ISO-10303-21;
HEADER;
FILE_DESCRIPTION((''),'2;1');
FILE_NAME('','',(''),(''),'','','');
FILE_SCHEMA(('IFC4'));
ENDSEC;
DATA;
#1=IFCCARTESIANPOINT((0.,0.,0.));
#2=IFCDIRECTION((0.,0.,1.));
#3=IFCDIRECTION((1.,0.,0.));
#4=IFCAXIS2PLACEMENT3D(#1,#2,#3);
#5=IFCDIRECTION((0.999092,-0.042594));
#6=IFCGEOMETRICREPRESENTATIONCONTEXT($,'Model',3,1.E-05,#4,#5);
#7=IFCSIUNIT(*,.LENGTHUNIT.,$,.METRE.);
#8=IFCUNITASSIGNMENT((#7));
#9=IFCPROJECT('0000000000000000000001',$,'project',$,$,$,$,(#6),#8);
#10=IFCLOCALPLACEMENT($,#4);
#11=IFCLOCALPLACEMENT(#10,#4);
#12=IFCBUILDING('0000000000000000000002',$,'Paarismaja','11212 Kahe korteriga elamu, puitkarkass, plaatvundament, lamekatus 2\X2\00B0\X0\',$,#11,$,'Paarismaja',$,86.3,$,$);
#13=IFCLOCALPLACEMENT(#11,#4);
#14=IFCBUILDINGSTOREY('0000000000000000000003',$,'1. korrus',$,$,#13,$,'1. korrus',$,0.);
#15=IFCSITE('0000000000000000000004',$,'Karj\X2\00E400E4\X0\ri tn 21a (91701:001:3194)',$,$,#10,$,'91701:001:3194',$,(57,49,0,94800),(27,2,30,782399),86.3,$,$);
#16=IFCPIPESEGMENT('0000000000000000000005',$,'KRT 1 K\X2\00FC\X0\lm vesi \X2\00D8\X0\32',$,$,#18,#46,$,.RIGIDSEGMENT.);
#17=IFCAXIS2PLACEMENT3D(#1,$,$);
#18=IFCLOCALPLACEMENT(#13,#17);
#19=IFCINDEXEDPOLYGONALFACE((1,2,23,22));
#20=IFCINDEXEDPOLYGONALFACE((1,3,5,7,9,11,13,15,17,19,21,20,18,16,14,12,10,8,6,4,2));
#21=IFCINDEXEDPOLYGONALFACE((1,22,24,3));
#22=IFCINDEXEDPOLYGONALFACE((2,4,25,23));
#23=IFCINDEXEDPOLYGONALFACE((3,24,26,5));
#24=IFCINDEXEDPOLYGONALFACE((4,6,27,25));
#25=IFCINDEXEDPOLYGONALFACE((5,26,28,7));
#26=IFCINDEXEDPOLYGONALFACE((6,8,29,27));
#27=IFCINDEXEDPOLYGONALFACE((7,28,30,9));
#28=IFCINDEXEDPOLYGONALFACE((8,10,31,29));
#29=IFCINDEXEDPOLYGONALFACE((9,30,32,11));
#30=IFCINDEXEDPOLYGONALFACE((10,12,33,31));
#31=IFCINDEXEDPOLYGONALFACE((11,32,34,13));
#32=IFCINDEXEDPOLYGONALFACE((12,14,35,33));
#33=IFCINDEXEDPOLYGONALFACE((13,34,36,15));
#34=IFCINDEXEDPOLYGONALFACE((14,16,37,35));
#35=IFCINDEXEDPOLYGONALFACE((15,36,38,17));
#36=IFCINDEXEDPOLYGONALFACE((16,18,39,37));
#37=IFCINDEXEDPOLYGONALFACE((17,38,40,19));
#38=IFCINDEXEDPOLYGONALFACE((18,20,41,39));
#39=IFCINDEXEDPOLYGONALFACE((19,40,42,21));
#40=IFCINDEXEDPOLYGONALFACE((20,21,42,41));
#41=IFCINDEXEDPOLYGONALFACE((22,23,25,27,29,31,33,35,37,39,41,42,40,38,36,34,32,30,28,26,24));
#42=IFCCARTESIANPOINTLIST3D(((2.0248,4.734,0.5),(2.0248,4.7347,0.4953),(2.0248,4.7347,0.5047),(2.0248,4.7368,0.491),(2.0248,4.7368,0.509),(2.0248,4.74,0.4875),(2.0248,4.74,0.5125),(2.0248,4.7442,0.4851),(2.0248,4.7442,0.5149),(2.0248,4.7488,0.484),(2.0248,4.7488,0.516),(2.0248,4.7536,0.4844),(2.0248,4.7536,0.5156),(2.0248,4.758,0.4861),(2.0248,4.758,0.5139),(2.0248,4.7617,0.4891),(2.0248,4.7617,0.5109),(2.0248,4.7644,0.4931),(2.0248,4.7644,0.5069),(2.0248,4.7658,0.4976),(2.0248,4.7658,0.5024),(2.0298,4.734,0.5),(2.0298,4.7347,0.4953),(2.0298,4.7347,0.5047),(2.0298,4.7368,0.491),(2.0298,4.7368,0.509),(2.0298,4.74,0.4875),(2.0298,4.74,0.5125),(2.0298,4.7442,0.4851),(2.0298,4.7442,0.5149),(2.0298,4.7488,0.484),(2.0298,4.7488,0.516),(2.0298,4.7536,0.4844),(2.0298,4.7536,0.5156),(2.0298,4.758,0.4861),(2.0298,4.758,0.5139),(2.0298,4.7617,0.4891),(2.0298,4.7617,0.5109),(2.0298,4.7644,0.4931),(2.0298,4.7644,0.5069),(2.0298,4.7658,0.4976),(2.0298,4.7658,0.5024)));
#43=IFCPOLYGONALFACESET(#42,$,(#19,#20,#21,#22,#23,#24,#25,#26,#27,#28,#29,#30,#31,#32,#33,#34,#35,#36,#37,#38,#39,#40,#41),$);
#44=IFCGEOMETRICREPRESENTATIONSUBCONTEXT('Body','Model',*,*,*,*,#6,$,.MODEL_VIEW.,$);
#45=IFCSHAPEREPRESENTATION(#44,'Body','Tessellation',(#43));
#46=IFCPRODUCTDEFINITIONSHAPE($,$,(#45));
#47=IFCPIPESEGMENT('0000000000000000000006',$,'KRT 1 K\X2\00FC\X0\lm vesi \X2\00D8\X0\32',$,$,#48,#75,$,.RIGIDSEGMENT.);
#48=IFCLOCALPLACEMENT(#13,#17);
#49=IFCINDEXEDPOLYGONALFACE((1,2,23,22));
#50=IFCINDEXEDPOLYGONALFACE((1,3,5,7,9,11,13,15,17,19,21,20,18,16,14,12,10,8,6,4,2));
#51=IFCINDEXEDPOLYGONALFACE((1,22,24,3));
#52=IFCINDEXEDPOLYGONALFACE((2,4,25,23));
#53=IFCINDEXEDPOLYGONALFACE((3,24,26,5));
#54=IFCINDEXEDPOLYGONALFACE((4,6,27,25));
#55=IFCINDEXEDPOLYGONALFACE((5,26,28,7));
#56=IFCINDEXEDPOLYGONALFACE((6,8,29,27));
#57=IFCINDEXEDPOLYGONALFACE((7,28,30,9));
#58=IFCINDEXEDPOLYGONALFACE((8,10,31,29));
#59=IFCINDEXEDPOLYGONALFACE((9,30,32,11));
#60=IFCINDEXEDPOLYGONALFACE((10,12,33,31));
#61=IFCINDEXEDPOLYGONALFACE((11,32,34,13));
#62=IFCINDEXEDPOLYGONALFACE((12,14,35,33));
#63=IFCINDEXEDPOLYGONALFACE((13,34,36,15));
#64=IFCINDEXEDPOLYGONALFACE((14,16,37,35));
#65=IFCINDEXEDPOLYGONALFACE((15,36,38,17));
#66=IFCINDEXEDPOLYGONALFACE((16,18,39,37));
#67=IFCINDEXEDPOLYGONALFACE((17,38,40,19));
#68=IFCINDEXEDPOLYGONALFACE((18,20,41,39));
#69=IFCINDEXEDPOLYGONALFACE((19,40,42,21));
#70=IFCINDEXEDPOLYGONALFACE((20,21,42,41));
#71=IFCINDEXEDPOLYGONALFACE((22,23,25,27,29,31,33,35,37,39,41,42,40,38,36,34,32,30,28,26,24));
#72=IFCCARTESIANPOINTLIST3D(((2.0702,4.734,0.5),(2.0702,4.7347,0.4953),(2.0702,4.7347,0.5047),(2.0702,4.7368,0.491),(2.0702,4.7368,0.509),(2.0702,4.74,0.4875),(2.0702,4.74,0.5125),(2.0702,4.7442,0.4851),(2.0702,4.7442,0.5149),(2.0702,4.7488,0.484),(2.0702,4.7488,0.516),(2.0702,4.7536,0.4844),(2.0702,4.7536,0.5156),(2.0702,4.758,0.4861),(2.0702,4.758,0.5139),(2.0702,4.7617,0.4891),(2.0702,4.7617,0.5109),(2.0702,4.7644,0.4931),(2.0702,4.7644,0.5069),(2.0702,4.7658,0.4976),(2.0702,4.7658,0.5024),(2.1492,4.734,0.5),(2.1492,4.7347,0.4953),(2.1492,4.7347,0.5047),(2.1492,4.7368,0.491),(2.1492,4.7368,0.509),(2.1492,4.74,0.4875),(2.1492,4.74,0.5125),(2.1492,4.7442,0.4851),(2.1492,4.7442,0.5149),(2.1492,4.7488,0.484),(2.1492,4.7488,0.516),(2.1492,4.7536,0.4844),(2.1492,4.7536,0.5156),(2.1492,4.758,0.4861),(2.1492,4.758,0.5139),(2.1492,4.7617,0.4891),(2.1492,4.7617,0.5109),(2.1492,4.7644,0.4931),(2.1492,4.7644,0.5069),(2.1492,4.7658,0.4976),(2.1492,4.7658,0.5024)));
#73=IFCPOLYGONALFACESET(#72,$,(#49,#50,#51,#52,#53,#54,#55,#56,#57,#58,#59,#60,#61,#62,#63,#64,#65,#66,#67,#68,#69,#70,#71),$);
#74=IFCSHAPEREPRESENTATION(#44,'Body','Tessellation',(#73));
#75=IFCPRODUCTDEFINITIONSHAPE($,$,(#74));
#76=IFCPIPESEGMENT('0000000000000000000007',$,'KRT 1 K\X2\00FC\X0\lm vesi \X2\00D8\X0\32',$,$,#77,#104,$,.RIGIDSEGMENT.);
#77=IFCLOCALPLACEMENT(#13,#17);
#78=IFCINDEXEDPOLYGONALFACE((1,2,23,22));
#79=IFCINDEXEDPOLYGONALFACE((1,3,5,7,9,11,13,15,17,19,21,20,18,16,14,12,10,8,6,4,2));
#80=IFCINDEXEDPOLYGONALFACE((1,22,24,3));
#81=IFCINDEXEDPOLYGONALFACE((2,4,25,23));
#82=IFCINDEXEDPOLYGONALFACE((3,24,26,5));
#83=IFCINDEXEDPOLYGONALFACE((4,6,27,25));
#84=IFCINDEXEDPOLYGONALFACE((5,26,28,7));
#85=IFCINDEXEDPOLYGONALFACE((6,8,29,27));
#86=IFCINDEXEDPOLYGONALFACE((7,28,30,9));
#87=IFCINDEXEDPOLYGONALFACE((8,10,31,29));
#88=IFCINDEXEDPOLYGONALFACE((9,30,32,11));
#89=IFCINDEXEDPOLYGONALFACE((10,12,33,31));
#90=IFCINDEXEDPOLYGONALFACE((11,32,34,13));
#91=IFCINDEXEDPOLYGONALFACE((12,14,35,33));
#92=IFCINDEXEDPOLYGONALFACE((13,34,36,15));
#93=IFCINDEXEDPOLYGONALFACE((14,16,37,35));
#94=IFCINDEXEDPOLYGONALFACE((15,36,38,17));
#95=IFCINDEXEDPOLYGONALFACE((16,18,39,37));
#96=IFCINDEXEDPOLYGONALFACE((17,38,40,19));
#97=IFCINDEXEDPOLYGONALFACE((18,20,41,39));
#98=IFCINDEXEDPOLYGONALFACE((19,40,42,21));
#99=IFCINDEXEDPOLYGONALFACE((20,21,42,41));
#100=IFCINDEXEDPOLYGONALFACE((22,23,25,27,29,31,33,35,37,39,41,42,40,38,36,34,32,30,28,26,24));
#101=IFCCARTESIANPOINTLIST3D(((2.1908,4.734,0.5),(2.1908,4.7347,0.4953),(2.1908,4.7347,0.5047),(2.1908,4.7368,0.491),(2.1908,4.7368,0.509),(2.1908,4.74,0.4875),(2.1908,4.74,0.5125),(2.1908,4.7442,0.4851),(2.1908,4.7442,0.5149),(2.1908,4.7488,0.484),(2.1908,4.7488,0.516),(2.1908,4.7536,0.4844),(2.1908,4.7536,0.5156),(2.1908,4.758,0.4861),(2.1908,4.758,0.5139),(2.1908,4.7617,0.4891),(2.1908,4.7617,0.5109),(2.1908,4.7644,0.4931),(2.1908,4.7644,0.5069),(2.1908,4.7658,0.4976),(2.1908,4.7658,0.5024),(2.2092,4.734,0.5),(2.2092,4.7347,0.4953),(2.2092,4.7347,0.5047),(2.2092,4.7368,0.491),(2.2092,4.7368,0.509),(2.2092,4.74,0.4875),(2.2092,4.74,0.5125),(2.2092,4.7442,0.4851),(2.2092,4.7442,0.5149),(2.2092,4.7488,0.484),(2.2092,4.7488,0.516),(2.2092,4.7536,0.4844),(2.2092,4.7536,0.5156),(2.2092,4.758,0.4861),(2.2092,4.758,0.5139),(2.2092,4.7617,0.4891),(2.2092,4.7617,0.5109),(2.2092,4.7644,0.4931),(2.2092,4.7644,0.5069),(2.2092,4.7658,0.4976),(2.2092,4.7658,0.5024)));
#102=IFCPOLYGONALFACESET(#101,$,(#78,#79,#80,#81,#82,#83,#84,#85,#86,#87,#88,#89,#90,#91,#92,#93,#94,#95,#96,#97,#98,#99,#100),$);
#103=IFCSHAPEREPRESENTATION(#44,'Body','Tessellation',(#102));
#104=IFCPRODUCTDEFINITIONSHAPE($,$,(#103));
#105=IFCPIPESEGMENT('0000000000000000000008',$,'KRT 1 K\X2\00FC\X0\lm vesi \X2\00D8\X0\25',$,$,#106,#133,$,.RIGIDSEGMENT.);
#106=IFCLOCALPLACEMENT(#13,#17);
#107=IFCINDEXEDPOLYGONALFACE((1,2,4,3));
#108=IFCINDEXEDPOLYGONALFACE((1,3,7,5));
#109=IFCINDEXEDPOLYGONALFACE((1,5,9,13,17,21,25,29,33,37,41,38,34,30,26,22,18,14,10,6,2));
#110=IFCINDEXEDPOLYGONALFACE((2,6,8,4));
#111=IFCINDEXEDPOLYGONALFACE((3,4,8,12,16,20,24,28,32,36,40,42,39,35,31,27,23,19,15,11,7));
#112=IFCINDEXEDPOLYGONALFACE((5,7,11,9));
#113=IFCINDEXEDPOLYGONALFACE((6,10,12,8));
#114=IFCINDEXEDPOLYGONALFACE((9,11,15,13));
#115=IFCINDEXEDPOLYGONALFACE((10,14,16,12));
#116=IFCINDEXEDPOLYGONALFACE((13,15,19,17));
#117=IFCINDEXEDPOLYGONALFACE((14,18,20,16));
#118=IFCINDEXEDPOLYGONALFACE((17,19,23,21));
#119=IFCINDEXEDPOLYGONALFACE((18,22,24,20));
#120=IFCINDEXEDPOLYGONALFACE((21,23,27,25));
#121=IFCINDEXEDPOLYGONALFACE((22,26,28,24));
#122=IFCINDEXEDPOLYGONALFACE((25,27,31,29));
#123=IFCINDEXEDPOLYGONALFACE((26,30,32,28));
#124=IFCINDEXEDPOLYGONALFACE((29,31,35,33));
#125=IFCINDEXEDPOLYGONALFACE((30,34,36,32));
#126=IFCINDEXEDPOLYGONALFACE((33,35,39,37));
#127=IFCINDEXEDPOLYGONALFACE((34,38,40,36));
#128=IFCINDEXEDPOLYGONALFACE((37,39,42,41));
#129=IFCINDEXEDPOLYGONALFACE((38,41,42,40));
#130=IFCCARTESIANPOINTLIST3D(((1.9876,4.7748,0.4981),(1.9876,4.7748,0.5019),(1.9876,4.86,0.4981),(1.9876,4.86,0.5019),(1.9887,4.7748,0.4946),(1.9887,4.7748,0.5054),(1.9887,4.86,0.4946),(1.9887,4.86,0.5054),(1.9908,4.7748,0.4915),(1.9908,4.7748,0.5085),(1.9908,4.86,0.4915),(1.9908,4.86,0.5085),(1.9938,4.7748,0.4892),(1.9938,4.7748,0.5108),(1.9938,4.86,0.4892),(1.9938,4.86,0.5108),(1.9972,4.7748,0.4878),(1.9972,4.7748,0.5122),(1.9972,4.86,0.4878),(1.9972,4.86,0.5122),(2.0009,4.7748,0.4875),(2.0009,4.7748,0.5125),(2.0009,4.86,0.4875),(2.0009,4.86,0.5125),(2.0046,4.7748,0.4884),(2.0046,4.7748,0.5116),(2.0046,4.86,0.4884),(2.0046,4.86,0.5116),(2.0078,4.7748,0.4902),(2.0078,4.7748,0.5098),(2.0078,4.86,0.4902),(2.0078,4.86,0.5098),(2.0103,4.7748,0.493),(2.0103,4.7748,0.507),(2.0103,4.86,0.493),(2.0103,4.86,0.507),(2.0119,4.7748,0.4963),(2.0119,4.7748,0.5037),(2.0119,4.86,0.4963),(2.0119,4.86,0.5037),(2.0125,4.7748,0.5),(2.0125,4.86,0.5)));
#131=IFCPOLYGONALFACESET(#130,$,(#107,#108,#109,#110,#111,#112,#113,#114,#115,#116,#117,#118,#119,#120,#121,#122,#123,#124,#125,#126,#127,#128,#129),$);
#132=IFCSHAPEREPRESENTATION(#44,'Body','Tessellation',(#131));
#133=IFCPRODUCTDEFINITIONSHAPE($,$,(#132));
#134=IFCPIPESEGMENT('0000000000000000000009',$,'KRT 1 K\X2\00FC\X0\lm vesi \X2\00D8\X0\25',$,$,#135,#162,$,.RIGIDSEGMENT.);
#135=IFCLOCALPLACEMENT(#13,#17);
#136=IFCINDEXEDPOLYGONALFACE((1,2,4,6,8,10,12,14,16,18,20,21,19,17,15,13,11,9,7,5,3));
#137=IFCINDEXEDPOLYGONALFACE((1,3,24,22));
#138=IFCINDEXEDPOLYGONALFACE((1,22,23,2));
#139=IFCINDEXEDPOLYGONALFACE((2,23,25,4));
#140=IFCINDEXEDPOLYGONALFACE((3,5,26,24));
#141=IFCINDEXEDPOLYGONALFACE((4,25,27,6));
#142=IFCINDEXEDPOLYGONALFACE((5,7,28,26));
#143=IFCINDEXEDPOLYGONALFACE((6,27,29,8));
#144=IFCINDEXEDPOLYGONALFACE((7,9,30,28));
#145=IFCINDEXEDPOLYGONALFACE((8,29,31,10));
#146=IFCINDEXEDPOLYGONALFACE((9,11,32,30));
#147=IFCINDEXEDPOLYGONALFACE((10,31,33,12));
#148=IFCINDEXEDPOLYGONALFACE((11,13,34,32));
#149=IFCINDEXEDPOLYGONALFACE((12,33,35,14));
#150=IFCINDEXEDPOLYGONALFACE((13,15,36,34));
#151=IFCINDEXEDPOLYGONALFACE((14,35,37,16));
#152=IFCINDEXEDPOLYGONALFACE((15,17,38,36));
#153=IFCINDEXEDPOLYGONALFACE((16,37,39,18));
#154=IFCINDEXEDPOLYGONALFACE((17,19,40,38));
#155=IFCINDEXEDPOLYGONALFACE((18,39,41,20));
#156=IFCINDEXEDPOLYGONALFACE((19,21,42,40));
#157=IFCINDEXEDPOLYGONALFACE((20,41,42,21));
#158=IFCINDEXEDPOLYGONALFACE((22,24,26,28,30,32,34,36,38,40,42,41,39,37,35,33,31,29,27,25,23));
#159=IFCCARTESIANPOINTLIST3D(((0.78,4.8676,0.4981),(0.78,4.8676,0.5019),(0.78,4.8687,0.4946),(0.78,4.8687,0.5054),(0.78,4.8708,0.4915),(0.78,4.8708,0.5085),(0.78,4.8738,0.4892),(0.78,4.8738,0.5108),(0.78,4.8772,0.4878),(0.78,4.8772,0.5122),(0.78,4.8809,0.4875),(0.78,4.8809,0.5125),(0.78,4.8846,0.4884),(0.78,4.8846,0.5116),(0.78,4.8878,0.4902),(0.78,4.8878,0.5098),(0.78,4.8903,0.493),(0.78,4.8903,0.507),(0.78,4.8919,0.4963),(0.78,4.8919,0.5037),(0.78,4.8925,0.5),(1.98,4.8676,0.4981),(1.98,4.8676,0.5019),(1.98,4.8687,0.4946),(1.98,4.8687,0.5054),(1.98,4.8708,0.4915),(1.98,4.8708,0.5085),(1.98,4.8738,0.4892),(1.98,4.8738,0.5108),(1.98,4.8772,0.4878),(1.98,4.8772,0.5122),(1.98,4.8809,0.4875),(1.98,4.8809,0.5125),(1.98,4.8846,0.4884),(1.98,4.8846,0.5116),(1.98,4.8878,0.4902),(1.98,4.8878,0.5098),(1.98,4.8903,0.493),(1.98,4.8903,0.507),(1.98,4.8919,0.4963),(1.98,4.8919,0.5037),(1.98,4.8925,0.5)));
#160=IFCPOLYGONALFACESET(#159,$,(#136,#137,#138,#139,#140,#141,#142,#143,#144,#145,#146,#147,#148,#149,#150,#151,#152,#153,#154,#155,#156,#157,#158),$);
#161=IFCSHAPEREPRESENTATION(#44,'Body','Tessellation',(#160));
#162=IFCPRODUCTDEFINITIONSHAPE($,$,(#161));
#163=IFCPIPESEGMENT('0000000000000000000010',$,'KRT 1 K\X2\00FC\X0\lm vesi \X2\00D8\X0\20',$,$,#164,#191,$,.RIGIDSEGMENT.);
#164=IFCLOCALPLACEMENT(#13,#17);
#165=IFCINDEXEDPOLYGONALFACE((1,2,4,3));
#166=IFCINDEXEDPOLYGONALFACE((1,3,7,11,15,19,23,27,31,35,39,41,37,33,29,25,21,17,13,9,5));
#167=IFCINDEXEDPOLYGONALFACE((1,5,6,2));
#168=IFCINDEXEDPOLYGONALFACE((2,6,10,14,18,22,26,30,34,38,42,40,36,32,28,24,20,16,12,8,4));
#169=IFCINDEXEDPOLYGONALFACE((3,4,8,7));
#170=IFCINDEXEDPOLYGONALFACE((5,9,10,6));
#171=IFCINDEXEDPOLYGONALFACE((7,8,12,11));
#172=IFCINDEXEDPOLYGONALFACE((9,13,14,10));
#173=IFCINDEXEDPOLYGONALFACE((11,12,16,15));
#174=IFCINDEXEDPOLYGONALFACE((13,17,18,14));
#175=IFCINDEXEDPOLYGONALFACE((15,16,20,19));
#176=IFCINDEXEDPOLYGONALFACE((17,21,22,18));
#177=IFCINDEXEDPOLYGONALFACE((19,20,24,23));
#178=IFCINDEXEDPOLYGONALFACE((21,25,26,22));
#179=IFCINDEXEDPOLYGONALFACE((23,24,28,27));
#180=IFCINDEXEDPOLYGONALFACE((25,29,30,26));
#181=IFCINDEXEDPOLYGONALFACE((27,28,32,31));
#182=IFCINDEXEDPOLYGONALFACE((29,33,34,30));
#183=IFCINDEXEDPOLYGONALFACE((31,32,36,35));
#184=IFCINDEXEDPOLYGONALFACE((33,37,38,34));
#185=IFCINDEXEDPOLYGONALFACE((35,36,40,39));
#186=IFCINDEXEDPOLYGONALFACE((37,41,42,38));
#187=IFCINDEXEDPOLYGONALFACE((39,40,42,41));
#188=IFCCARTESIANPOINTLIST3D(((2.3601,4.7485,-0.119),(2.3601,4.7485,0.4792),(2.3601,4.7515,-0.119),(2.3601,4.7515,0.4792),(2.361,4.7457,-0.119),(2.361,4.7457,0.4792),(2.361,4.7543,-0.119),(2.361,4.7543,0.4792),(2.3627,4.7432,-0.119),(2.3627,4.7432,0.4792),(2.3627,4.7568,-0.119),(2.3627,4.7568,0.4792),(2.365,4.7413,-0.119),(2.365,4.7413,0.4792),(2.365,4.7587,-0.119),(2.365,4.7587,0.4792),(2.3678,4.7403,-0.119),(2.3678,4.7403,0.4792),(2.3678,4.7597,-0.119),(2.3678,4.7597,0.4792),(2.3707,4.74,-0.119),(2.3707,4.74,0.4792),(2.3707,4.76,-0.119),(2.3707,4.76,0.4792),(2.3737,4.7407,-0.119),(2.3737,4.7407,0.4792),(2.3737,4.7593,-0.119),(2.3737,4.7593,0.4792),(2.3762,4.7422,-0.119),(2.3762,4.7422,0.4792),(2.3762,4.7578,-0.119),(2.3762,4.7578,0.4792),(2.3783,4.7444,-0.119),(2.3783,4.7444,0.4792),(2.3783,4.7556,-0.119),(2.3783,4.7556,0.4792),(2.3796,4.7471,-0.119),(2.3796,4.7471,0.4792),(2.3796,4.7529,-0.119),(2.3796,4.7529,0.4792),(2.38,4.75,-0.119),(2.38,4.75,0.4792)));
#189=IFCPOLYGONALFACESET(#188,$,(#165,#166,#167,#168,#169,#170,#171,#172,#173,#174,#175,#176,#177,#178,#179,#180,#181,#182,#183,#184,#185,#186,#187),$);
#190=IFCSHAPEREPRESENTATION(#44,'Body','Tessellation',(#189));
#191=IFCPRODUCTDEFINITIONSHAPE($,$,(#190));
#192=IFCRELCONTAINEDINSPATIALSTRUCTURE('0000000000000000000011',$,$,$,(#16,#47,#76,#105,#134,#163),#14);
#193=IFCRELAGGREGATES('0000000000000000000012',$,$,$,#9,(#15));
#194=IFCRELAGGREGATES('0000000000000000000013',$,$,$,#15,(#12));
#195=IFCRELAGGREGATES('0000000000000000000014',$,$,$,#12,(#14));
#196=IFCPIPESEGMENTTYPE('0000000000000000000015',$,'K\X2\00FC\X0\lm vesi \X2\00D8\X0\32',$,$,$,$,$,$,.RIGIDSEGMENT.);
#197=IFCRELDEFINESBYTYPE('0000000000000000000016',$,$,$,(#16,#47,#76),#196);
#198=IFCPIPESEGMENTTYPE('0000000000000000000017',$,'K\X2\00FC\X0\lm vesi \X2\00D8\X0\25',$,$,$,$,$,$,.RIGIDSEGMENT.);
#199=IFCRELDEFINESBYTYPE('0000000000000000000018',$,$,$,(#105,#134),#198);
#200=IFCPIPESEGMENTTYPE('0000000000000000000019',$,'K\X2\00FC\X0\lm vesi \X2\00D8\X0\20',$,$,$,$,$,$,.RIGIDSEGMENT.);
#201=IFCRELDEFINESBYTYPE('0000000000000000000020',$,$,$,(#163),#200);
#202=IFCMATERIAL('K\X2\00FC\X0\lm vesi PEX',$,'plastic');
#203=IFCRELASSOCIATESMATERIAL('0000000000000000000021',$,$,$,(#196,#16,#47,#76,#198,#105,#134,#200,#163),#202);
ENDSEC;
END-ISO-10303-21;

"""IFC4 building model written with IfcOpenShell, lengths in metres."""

from ifc_helpers import new_model, si_unit, direction, frame, origin_with_axes, place, context, subcontext, project, spatial, circle, extrude, material, type_object, element, save


model = new_model("IFC4")

# Units and contexts
model_context = context("Model", 3, precision=1e-05, world=origin_with_axes(), true_north=direction((0.999092, -0.042594)))
body_context = subcontext(model_context, "Body", "Model", "MODEL_VIEW")
ifc_project = project(units=[si_unit("LENGTHUNIT", "METRE")], contexts=[model_context])

# Site, building, storey
site_placement = place(None, origin_with_axes())
site = spatial("IfcSite", under=ifc_project, at=site_placement, Name="Karjääri tn 21a (91701:001:3194)", LongName="91701:001:3194", RefLatitude=(57, 49, 0, 94800), RefLongitude=(27, 2, 30, 782399), RefElevation=86.3)
building_placement = place(site_placement, origin_with_axes())
building = spatial("IfcBuilding", under=site, at=building_placement, Name="Paarismaja", Description="11212 Kahe korteriga elamu, puitkarkass, plaatvundament, lamekatus 2°", LongName="Paarismaja", ElevationOfRefHeight=86.3)
storey_placement = place(building_placement, origin_with_axes())
storey = spatial("IfcBuildingStorey", under=building, at=storey_placement, Name="1. korrus", LongName="1. korrus", Elevation=0.0)

# Shared definitions
ifc_material_1 = material(Name="Külm vesi PEX", Category="plastic")

# Pipe segments
pipe_segment_type_1 = type_object("IfcPipeSegmentType", Name="Külm vesi Ø32", PredefinedType="RIGIDSEGMENT", material=ifc_material_1)
pipe_segment_1_placement = place(storey_placement, frame((2.0248, 4.75, 0.5), z_axis=(1.0, 0.0, 0.0), x_axis=(0.0, -1.0, 0.0)))
element("IfcPipeSegment", 1, at=pipe_segment_1_placement, inside=storey, type_object=pipe_segment_type_1, material=ifc_material_1, Name="KRT 1 Külm vesi Ø32", PredefinedType="RIGIDSEGMENT", context=body_context, shape_type="SweptSolid", body=[
    extrude(circle(Radius=0.016), origin_with_axes(), (0.0, 0.0, 1.0), 0.005),
])
pipe_segment_2_placement = place(storey_placement, frame((2.0702, 4.75, 0.5), z_axis=(1.0, 0.0, 0.0), x_axis=(0.0, -1.0, 0.0)))
element("IfcPipeSegment", 2, at=pipe_segment_2_placement, inside=storey, type_object=pipe_segment_type_1, material=ifc_material_1, Name="KRT 1 Külm vesi Ø32", PredefinedType="RIGIDSEGMENT", context=body_context, shape_type="SweptSolid", body=[
    extrude(circle(Radius=0.016), origin_with_axes(), (0.0, 0.0, 1.0), 0.079),
])
pipe_segment_3_placement = place(storey_placement, frame((2.1908, 4.75, 0.5), z_axis=(1.0, 0.0, 0.0), x_axis=(0.0, -1.0, 0.0)))
element("IfcPipeSegment", 3, at=pipe_segment_3_placement, inside=storey, type_object=pipe_segment_type_1, material=ifc_material_1, Name="KRT 1 Külm vesi Ø32", PredefinedType="RIGIDSEGMENT", context=body_context, shape_type="SweptSolid", body=[
    extrude(circle(Radius=0.016), origin_with_axes(), (0.0, 0.0, 1.0), 0.0184),
])
pipe_segment_type_2 = type_object("IfcPipeSegmentType", Name="Külm vesi Ø25", PredefinedType="RIGIDSEGMENT", material=ifc_material_1)
pipe_segment_4_placement = place(storey_placement, frame((2.0, 4.7748, 0.5), z_axis=(0.0, 1.0, 0.0), x_axis=(1.0, 0.0, 0.0)))
element("IfcPipeSegment", 4, at=pipe_segment_4_placement, inside=storey, type_object=pipe_segment_type_2, material=ifc_material_1, Name="KRT 1 Külm vesi Ø25", PredefinedType="RIGIDSEGMENT", context=body_context, shape_type="SweptSolid", body=[
    extrude(circle(Radius=0.0125), origin_with_axes(), (0.0, 0.0, 1.0), 0.0852),
])
pipe_segment_5_placement = place(storey_placement, frame((1.98, 4.88, 0.5), z_axis=(-1.0, 0.0, 0.0), x_axis=(0.0, 1.0, 0.0)))
element("IfcPipeSegment", 5, at=pipe_segment_5_placement, inside=storey, type_object=pipe_segment_type_2, material=ifc_material_1, Name="KRT 1 Külm vesi Ø25", PredefinedType="RIGIDSEGMENT", context=body_context, shape_type="SweptSolid", body=[
    extrude(circle(Radius=0.0125), origin_with_axes(), (0.0, 0.0, 1.0), 1.2),
])
pipe_segment_type_3 = type_object("IfcPipeSegmentType", Name="Külm vesi Ø20", PredefinedType="RIGIDSEGMENT", material=ifc_material_1)
pipe_segment_6_placement = place(storey_placement, frame((2.37, 4.75, 0.4792), z_axis=(0.0, 0.0, -1.0), x_axis=(1.0, 0.0, 0.0)))
element("IfcPipeSegment", 6, at=pipe_segment_6_placement, inside=storey, type_object=pipe_segment_type_3, material=ifc_material_1, Name="KRT 1 Külm vesi Ø20", PredefinedType="RIGIDSEGMENT", context=body_context, shape_type="SweptSolid", body=[
    extrude(circle(Radius=0.01), origin_with_axes(), (0.0, 0.0, 1.0), 0.5982),
])

save(model, "model.ifc")
